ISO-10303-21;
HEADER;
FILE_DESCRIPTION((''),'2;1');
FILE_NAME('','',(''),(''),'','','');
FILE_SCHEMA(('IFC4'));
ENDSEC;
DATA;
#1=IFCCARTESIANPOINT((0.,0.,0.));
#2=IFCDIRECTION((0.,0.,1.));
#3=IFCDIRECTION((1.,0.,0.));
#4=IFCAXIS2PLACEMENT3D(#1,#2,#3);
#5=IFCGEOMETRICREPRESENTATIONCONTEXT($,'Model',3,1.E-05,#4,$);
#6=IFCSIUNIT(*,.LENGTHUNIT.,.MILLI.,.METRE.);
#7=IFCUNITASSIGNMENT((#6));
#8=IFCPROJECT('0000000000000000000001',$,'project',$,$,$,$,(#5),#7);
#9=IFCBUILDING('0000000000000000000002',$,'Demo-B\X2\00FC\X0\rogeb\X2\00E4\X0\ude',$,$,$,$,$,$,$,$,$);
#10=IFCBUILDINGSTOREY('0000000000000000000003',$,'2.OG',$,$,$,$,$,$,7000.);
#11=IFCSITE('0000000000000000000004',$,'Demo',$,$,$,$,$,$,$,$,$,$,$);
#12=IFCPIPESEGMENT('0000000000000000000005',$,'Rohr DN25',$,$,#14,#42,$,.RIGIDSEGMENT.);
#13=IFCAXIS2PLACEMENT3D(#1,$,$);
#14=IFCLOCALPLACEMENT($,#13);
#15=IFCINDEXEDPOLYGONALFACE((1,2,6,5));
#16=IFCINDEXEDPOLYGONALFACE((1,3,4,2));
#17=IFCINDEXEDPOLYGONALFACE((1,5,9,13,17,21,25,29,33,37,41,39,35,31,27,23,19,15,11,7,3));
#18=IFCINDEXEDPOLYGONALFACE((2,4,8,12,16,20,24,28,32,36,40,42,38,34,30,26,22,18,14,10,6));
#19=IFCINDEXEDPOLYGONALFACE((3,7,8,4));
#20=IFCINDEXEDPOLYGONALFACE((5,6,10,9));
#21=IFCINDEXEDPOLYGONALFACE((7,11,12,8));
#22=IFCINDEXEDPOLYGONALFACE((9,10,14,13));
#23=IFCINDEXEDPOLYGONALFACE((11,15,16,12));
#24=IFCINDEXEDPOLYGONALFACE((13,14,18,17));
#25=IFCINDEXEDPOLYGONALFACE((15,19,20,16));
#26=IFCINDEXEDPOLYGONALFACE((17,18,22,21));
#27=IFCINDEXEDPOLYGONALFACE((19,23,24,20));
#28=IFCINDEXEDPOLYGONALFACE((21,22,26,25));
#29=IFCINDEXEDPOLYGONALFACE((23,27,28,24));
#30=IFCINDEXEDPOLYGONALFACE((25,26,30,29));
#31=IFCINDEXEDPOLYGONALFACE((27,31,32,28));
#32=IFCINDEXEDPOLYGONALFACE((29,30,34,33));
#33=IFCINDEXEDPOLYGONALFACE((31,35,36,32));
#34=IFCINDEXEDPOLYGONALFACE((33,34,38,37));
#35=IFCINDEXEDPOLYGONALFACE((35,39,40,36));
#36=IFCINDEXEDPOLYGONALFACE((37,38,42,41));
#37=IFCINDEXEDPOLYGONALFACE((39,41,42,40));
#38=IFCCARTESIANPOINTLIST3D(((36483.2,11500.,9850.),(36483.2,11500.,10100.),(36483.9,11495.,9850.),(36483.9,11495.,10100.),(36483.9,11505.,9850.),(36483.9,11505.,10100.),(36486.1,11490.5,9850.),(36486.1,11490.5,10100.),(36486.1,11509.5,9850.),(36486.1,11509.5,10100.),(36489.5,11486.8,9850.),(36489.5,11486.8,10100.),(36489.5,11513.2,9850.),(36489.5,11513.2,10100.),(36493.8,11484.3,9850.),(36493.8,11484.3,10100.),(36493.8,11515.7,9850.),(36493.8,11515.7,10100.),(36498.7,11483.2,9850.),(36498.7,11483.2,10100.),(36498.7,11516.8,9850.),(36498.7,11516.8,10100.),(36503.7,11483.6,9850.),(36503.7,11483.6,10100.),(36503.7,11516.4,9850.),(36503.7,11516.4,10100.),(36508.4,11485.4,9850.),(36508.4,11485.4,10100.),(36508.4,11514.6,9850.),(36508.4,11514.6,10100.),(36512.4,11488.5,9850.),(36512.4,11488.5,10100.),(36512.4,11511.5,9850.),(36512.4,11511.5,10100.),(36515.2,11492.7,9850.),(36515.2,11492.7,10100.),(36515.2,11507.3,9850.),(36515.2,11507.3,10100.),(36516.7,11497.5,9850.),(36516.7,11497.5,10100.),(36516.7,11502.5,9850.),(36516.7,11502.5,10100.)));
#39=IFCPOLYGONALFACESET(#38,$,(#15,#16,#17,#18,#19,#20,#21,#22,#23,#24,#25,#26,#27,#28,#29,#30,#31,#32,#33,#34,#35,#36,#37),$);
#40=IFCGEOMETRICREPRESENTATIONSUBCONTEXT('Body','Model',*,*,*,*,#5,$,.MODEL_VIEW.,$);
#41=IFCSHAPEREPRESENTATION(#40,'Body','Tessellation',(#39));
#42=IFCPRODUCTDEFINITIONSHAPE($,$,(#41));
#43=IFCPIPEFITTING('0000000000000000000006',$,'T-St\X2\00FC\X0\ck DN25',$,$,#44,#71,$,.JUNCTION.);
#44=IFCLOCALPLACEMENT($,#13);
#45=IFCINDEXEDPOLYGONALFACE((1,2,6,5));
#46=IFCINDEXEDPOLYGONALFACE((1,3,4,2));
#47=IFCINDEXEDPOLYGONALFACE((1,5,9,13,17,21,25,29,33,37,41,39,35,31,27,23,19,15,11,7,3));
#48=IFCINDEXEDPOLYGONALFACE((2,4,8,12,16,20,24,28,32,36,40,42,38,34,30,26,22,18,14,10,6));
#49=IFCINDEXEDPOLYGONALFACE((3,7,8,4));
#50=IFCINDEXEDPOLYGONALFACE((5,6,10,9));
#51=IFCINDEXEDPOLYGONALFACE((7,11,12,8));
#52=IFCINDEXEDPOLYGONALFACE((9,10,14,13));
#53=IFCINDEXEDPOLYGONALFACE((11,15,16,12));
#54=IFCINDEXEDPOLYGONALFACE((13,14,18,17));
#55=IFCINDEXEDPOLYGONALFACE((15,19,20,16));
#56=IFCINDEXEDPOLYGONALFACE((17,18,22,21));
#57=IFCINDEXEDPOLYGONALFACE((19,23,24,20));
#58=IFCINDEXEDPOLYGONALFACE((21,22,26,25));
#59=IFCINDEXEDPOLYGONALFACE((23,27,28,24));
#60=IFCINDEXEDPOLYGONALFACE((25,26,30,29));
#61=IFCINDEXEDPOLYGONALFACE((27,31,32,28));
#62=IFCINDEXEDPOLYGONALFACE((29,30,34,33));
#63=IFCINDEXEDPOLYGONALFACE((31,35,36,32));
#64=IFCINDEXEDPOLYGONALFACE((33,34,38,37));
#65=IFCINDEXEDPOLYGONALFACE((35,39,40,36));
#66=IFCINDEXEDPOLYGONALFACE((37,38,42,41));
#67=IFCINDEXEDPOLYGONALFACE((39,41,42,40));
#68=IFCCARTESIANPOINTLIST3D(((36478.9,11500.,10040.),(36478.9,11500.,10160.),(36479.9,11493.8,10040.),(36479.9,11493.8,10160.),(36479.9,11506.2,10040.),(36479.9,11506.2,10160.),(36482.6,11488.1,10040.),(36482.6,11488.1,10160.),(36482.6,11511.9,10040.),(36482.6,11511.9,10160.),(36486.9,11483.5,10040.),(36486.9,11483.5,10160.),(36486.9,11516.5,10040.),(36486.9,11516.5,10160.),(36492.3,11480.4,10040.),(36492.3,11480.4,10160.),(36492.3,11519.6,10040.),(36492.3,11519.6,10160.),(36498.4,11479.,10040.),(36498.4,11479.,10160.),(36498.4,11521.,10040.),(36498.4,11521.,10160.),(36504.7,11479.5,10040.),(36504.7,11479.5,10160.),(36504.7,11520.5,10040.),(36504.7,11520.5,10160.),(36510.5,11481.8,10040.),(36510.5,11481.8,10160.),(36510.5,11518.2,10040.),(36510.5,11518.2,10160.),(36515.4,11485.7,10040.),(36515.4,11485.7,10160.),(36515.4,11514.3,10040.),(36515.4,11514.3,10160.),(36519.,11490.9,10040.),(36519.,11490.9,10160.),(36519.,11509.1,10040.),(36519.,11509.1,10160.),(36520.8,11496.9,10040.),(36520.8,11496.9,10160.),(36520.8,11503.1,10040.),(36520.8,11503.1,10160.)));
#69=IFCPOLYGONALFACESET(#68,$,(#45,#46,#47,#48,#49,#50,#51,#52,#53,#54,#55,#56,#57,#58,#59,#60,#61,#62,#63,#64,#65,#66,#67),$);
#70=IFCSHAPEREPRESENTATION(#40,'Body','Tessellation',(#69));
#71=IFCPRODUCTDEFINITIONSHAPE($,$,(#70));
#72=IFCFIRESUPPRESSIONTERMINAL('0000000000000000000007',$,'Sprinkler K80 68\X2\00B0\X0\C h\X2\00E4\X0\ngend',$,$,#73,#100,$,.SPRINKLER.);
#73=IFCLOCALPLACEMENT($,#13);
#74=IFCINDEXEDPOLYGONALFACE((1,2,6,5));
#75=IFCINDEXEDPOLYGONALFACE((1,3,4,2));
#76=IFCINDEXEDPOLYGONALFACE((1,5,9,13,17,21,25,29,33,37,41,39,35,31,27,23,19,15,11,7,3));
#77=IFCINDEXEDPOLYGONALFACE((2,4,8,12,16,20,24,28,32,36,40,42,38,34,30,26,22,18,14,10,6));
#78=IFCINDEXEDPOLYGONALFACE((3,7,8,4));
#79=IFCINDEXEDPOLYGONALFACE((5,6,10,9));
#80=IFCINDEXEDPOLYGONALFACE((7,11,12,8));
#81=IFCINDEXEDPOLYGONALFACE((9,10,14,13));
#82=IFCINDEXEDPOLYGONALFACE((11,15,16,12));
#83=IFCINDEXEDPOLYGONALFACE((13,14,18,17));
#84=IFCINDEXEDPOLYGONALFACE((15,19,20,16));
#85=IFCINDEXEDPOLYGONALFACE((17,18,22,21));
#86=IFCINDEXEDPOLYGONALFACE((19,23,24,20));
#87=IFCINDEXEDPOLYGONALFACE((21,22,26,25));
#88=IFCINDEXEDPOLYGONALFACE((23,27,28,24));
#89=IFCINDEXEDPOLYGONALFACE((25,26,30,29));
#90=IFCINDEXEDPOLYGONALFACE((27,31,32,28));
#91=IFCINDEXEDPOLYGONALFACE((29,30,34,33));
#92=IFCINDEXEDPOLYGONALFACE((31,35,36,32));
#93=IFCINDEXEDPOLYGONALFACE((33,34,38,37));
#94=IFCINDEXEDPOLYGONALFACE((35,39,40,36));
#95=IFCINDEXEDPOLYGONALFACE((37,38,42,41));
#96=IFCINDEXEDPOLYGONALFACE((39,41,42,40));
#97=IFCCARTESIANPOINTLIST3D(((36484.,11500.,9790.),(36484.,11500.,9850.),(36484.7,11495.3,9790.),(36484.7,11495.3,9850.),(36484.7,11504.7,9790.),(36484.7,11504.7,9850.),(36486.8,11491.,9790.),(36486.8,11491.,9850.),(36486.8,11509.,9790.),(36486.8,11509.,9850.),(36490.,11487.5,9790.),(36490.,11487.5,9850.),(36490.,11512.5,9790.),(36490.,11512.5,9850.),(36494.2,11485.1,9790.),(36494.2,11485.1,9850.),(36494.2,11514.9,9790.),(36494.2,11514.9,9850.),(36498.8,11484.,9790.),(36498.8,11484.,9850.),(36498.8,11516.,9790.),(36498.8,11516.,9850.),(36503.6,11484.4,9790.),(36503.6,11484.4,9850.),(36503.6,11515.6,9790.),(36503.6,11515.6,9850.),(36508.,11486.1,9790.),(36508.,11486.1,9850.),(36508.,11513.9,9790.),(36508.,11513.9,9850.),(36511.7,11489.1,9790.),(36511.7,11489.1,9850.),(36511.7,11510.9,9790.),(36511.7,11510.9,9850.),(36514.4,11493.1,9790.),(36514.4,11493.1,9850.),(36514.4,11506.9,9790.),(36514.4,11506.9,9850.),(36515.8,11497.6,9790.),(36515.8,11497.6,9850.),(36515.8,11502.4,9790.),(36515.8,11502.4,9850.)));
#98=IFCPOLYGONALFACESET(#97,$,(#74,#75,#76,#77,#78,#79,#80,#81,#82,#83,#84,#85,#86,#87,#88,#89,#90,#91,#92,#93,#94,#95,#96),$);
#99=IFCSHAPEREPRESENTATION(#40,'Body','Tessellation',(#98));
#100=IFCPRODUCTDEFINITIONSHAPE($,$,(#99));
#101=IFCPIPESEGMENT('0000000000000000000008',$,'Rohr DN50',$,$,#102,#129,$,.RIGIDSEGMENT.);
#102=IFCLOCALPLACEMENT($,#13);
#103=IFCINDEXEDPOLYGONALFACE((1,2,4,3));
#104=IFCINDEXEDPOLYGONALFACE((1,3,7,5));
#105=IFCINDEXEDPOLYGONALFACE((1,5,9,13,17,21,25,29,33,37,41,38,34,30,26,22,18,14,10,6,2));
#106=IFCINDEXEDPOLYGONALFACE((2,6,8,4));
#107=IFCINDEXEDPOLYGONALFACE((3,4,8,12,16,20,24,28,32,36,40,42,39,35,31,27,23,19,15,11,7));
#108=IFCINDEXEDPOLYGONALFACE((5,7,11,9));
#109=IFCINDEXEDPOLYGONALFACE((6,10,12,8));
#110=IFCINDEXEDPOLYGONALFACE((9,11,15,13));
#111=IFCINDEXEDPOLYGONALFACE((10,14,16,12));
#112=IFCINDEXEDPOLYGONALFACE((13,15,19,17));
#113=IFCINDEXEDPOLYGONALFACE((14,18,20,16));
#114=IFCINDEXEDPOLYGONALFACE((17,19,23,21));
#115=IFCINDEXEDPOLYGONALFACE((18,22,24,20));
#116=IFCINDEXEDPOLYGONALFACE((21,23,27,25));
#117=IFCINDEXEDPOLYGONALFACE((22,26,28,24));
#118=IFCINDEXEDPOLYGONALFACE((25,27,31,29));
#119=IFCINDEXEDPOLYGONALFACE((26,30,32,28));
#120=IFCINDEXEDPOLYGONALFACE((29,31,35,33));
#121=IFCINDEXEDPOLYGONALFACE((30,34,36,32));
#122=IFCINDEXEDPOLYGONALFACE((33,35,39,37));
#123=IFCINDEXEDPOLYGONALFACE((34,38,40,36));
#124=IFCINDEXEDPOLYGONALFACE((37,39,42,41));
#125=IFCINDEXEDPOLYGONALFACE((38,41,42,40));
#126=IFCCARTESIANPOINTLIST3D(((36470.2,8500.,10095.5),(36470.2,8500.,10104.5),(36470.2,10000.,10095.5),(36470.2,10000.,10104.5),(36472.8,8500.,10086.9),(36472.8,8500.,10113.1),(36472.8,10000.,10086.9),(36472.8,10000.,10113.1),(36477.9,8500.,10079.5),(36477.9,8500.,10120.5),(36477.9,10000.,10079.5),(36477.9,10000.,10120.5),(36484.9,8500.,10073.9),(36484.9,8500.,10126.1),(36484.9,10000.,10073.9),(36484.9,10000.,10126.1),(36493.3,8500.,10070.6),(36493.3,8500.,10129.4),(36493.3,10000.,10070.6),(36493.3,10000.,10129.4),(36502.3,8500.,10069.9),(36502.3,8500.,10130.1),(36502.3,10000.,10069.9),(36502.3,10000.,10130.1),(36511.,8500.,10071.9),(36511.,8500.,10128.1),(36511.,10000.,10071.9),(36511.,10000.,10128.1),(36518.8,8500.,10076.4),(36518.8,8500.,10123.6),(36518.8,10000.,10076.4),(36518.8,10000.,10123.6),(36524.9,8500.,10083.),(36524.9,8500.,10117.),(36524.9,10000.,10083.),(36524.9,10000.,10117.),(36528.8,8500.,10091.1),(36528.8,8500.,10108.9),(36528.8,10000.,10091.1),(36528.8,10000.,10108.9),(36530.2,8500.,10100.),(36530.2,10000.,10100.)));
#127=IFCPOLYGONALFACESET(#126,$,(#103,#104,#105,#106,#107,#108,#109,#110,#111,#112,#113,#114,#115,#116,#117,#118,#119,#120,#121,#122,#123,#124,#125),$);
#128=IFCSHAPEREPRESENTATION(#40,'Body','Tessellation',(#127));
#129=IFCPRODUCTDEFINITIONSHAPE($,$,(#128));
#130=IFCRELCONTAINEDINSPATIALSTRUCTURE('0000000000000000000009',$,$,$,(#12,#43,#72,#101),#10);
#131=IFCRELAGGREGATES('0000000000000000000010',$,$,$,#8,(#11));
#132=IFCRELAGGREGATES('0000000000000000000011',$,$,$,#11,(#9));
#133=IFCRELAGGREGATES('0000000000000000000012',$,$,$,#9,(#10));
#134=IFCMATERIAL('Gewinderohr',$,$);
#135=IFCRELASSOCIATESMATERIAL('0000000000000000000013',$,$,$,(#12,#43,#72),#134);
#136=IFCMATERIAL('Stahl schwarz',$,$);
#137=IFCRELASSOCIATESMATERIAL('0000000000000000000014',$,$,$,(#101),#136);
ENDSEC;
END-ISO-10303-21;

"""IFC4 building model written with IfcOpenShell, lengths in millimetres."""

from ifc_helpers import new_model, si_unit, frame, origin_with_axes, place, context, subcontext, project, spatial, circle, extrude, material, element, save


model = new_model("IFC4")

# Units and contexts
model_context = context("Model", 3, precision=1e-05, world=origin_with_axes())
body_context = subcontext(model_context, "Body", "Model", "MODEL_VIEW")
ifc_project = project(units=[si_unit("LENGTHUNIT", "METRE", prefix="MILLI")], contexts=[model_context])

# Site, building, storey
site = spatial("IfcSite", under=ifc_project, Name="Demo")
building = spatial("IfcBuilding", under=site, Name="Demo-Bürogebäude")
storey = spatial("IfcBuildingStorey", under=building, Name="2.OG", Elevation=7000.0)

# Shared definitions
ifc_material_1 = material(Name="Gewinderohr")

# Shared definitions
ifc_material_2 = material(Name="Stahl schwarz")

# Pipe segment
pipe_segment_1_placement = place(None, frame((36500.0, 11500.0, 10100.0), z_axis=(0.0, 0.0, -1.0), x_axis=(-1.0, 0.0, 0.0)))
element("IfcPipeSegment", 1, at=pipe_segment_1_placement, inside=storey, material=ifc_material_1, Name="Rohr DN25", PredefinedType="RIGIDSEGMENT", context=body_context, shape_type="SweptSolid", body=[
    extrude(circle(Radius=16.9), origin_with_axes(), (0.0, 0.0, 1.0), 250.0),
])

# Pipe fitting
pipe_fitting_1_placement = place(None, frame((36500.0, 11500.0, 10160.0), z_axis=(0.0, 0.0, -1.0), x_axis=(-1.0, 0.0, 0.0)))
element("IfcPipeFitting", 2, at=pipe_fitting_1_placement, inside=storey, material=ifc_material_1, Name="T-Stück DN25", PredefinedType="JUNCTION", context=body_context, shape_type="SweptSolid", body=[
    extrude(circle(Radius=21.1), origin_with_axes(), (0.0, 0.0, 1.0), 120.0),
])

# Fire suppression terminal
fire_suppression_terminal_1_placement = place(None, frame((36500.0, 11500.0, 9850.0), z_axis=(0.0, 0.0, -1.0), x_axis=(-1.0, 0.0, 0.0)))
element("IfcFireSuppressionTerminal", 3, at=fire_suppression_terminal_1_placement, inside=storey, material=ifc_material_1, Name="Sprinkler K80 68°C hängend", PredefinedType="SPRINKLER", context=body_context, shape_type="SweptSolid", body=[
    extrude(circle(Radius=16.0), origin_with_axes(), (0.0, 0.0, 1.0), 60.0),
])

# Pipe segment
pipe_segment_2_placement = place(None, frame((36500.0, 10000.0, 10100.0), z_axis=(0.0, -1.0, 0.0), x_axis=(1.0, 0.0, 0.0)))
element("IfcPipeSegment", 4, at=pipe_segment_2_placement, inside=storey, material=ifc_material_2, Name="Rohr DN50", PredefinedType="RIGIDSEGMENT", context=body_context, shape_type="SweptSolid", body=[
    extrude(circle(Radius=30.1), origin_with_axes(), (0.0, 0.0, 1.0), 1500.0),
])

save(model, "model.ifc")
